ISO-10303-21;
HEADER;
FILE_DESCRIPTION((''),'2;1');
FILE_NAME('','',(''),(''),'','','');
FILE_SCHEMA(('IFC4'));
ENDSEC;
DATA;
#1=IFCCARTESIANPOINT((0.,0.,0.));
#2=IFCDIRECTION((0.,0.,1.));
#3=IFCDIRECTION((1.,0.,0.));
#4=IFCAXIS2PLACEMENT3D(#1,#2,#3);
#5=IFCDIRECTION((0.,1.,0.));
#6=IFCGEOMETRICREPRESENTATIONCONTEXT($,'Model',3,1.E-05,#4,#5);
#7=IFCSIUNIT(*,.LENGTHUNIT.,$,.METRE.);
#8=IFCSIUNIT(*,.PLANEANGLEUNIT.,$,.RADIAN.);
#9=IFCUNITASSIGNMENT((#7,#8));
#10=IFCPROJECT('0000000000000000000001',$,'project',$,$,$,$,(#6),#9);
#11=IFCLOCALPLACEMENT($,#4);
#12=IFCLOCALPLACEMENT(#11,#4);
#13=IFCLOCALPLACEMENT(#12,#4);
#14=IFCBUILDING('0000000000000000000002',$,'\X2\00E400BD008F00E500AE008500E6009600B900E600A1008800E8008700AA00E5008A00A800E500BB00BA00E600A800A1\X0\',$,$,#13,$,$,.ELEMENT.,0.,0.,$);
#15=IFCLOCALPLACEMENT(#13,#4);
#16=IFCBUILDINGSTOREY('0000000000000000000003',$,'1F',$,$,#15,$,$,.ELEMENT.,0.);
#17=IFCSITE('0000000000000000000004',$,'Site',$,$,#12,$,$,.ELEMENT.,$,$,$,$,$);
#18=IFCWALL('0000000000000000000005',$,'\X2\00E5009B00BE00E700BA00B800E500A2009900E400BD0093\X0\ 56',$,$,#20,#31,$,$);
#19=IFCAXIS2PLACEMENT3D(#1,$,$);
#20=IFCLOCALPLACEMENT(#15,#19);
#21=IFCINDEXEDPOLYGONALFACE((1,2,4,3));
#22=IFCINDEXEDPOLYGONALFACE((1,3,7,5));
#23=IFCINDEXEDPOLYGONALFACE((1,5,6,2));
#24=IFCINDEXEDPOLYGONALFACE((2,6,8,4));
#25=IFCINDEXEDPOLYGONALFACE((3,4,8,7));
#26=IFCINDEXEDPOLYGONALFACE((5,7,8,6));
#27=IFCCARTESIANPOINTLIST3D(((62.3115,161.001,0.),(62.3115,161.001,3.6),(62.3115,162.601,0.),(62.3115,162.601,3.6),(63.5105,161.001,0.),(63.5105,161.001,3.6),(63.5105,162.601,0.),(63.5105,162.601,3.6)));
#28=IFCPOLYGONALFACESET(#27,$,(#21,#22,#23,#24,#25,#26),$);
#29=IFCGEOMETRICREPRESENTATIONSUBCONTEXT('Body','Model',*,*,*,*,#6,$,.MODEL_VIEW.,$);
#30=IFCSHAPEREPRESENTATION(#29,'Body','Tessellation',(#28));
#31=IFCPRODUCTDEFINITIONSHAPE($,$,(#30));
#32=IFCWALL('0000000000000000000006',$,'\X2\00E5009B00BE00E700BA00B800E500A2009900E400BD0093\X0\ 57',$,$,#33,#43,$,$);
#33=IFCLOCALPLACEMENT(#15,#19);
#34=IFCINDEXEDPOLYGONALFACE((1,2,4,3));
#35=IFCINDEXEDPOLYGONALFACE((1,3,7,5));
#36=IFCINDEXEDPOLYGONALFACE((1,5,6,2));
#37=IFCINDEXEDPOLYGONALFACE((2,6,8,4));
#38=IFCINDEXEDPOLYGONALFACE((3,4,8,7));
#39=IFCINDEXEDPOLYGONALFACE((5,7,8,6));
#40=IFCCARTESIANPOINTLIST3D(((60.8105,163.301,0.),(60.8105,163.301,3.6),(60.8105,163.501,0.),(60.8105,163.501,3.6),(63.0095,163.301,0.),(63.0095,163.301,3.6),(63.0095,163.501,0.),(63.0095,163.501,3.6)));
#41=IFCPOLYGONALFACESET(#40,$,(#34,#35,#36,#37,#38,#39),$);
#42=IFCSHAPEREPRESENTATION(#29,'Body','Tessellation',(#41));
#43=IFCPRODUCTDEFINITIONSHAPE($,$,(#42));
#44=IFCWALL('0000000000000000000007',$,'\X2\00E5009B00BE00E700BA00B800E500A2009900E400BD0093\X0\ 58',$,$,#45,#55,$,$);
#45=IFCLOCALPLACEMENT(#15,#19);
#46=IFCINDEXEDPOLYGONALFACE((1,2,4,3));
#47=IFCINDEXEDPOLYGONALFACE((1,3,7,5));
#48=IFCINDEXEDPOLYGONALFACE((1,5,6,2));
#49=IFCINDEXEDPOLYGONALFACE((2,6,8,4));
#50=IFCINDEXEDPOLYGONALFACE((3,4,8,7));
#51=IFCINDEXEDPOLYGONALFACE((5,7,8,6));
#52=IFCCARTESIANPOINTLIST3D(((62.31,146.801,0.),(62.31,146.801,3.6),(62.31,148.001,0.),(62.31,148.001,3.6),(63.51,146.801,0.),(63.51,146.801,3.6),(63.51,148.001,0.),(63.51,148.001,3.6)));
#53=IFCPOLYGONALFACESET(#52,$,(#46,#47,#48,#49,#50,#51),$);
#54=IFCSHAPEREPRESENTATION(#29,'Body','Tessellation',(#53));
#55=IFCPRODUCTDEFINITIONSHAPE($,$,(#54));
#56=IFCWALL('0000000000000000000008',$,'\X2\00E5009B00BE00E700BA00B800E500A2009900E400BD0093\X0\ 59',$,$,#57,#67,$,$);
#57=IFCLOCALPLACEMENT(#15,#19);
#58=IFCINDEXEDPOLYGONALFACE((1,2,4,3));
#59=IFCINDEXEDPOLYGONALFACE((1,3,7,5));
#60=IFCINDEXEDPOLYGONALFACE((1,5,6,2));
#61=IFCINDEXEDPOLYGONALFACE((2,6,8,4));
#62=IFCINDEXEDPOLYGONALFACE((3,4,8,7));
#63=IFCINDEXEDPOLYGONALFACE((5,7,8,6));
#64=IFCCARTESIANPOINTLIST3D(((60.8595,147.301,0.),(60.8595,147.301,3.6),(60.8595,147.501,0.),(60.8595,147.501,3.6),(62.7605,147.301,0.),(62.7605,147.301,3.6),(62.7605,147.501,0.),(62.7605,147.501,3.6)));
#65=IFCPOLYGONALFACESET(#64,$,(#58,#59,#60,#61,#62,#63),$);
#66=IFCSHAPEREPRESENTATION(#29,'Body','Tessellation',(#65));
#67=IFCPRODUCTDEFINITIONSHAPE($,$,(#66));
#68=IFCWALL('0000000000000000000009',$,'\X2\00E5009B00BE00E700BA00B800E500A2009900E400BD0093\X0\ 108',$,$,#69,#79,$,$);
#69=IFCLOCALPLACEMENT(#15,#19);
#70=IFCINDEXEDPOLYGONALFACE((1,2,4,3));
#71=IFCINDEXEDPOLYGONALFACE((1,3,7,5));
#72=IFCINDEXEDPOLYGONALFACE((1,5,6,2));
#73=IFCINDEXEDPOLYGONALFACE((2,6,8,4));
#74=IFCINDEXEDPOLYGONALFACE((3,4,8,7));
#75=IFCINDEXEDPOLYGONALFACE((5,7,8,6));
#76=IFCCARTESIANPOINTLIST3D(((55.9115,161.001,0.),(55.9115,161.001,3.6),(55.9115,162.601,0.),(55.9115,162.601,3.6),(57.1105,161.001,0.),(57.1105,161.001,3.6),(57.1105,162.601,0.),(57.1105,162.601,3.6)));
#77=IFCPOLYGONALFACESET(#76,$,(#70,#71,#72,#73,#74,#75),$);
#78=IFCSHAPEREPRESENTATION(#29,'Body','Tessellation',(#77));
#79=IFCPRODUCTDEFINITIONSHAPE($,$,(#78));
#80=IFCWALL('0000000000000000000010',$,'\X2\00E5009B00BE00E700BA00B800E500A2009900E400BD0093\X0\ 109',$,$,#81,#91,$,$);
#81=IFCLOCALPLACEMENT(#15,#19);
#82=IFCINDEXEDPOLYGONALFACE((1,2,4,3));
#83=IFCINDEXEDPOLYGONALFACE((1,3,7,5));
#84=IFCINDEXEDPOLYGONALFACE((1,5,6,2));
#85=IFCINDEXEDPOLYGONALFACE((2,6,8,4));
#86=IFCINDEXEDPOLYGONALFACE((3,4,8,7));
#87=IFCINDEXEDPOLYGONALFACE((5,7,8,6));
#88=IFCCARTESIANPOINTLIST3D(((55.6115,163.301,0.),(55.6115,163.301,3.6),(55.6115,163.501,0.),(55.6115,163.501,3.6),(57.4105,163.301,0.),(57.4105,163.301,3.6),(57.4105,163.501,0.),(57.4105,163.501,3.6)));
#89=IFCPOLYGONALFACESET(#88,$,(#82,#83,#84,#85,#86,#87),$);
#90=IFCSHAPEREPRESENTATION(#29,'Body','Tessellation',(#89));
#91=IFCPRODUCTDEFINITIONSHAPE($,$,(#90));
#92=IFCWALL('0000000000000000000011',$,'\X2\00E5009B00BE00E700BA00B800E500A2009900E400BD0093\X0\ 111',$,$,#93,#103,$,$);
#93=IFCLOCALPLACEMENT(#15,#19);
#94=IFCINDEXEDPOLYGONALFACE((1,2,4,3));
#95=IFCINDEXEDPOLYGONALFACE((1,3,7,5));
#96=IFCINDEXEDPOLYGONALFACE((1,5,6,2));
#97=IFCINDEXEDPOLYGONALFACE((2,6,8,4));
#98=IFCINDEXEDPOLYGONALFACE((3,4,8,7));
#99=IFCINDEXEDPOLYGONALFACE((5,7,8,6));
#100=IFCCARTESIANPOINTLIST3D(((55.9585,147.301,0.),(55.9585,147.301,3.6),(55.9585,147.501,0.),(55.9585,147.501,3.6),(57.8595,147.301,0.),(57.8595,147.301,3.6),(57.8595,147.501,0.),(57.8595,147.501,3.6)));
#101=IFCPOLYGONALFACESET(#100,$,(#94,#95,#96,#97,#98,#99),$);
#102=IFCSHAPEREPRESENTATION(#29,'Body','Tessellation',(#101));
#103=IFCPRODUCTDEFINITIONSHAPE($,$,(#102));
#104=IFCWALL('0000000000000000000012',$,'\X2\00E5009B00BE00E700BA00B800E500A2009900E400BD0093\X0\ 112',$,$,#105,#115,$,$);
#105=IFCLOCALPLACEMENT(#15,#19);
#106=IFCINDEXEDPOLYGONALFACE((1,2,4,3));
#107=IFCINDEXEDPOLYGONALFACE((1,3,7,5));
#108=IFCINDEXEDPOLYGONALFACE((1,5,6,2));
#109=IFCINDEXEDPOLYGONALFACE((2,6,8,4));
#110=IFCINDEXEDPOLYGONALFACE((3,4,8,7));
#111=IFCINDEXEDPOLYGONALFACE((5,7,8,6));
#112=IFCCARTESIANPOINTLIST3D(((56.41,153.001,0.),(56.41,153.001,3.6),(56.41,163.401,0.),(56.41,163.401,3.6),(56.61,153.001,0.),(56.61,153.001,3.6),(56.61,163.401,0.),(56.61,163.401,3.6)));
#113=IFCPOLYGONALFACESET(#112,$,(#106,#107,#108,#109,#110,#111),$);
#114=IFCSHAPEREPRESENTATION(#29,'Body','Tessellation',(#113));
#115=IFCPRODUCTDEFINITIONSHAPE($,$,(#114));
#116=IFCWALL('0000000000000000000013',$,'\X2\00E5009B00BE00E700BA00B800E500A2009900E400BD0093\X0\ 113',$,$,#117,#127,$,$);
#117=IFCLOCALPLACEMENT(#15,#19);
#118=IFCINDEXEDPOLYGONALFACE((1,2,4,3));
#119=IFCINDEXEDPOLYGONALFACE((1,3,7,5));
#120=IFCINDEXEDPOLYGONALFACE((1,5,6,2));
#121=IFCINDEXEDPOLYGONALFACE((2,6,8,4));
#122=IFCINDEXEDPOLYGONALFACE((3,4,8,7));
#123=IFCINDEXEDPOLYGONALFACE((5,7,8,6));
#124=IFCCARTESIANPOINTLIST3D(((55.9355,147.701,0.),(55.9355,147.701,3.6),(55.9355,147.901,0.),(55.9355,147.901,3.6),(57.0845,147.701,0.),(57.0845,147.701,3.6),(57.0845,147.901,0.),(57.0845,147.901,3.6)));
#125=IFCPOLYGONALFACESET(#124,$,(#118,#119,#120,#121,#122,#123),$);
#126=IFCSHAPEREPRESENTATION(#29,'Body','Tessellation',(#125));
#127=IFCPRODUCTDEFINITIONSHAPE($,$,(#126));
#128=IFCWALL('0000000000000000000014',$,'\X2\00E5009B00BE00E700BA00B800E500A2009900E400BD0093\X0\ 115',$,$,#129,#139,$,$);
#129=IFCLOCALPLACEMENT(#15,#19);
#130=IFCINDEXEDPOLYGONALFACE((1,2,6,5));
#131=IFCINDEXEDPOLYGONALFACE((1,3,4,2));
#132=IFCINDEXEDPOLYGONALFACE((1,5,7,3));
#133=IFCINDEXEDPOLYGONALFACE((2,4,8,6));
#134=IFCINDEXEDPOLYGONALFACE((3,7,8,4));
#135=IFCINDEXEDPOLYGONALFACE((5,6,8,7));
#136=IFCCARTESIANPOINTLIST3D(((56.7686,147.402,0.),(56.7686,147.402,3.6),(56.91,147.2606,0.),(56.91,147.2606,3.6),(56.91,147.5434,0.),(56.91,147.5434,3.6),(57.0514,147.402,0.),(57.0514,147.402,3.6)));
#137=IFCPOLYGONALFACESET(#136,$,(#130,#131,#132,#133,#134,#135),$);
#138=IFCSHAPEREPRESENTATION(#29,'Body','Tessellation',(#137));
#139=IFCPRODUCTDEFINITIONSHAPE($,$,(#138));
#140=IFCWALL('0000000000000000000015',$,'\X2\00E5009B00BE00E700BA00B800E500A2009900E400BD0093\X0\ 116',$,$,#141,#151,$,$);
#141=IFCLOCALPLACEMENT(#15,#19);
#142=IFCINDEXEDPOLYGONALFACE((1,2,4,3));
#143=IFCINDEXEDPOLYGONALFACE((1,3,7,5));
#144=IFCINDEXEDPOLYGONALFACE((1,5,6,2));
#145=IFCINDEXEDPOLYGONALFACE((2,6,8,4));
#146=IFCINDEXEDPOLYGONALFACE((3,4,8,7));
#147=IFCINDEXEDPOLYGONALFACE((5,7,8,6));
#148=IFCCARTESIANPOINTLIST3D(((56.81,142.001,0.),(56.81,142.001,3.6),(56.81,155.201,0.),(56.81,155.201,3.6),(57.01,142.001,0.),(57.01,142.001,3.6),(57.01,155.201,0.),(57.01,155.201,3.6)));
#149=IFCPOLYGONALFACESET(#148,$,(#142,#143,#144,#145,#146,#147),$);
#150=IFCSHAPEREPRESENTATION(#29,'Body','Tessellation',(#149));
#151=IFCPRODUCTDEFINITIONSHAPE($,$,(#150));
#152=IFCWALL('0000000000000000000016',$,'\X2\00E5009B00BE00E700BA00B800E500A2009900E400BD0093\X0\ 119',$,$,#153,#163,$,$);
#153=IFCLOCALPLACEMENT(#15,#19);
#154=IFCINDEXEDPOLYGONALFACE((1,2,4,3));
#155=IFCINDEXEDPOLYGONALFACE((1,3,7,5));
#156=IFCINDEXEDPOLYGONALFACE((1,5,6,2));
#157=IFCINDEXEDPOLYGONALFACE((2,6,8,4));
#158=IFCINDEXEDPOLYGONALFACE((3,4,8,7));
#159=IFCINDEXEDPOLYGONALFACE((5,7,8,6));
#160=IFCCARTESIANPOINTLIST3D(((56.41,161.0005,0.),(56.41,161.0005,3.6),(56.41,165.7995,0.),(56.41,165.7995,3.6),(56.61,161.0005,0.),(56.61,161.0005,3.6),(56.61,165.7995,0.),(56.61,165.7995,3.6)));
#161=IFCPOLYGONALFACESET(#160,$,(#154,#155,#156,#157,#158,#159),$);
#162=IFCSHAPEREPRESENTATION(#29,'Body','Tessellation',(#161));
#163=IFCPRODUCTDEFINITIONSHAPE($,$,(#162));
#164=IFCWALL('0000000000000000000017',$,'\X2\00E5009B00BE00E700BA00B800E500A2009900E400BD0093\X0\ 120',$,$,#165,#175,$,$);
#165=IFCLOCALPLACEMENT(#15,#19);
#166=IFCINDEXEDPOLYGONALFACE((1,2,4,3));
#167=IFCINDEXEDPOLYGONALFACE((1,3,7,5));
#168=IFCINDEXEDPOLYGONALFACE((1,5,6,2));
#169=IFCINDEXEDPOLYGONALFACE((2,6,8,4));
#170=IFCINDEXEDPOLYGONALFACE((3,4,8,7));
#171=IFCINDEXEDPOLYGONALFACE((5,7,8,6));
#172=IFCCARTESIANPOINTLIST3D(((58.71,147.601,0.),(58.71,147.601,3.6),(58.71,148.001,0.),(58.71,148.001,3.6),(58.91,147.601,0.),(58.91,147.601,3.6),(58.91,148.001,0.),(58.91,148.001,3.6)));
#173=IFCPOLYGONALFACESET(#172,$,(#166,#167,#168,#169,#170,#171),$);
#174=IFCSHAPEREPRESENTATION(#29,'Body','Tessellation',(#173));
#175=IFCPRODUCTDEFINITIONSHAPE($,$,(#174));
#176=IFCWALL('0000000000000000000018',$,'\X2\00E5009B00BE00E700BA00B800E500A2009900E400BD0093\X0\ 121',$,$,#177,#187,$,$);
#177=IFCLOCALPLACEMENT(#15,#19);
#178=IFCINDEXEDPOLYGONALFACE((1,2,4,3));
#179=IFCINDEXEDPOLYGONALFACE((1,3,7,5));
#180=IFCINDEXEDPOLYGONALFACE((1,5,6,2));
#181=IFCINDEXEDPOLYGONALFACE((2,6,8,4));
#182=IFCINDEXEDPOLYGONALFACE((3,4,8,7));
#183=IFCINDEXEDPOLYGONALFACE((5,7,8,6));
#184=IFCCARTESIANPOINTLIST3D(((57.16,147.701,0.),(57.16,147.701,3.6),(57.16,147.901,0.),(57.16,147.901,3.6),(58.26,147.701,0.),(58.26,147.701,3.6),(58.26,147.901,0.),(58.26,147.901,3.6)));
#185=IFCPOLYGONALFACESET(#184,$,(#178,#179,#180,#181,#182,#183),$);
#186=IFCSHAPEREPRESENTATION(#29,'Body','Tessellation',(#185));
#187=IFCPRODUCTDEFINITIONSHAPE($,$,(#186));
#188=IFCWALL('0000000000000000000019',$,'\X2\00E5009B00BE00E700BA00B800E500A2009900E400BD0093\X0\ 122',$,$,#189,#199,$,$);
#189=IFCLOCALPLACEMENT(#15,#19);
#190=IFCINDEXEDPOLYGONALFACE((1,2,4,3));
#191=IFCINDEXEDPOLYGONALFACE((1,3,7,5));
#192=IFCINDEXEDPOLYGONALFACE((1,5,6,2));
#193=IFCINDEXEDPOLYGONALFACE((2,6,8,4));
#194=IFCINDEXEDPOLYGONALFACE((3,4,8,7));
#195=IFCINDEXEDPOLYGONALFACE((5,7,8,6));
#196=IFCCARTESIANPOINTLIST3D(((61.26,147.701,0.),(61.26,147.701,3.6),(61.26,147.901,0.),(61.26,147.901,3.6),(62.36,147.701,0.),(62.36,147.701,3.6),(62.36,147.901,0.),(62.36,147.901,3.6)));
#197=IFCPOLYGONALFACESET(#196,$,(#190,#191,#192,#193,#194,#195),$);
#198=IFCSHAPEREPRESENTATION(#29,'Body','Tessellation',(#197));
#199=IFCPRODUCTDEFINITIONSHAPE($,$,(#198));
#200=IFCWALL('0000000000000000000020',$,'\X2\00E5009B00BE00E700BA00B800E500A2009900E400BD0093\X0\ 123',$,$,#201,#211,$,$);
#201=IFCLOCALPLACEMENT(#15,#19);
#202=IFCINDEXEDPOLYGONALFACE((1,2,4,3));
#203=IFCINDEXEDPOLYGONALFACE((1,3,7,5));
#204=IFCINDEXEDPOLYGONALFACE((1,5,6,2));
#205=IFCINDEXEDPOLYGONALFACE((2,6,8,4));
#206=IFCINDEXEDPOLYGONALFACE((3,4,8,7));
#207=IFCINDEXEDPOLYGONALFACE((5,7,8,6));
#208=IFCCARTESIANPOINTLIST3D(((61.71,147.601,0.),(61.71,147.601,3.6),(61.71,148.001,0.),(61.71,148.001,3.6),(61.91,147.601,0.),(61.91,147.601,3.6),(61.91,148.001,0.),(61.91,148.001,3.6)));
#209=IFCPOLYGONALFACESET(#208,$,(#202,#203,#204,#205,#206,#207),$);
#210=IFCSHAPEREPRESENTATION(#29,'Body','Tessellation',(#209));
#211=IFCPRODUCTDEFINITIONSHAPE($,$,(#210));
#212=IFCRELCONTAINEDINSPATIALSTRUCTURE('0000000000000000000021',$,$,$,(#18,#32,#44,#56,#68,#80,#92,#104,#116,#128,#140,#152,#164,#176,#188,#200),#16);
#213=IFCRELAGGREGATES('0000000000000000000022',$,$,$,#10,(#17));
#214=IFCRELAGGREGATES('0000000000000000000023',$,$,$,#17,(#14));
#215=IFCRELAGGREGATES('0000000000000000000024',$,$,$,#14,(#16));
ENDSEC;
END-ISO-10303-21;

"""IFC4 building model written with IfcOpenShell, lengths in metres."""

from ifc_helpers import new_model, si_unit, direction, frame, frame_2d, origin_with_axes, place, context, subcontext, project, spatial, rectangle, extrude, element, save


model = new_model("IFC4")

# Units and contexts
model_context = context("Model", 3, precision=1e-05, world=origin_with_axes(), true_north=direction((0.0, 1.0, 0.0)))
body_context = subcontext(model_context, "Body", "Model", "MODEL_VIEW")
ifc_project = project(units=[si_unit("LENGTHUNIT", "METRE"), si_unit("PLANEANGLEUNIT", "RADIAN")], contexts=[model_context])

# Site, building, storey
placement = place(None, origin_with_axes())
site_placement = place(placement, origin_with_axes())
site = spatial("IfcSite", under=ifc_project, at=site_placement, Name="Site", CompositionType="ELEMENT")
building_placement = place(site_placement, origin_with_axes())
building = spatial("IfcBuilding", under=site, at=building_placement, Name="ä½\u008få®\u0085æ\u0096¹æ¡\u0088è\u0087ªå\u008a¨å»ºæ¨¡", CompositionType="ELEMENT", ElevationOfRefHeight=0.0, ElevationOfTerrain=0.0)
storey_placement = place(building_placement, origin_with_axes())
storey = spatial("IfcBuildingStorey", under=building, at=storey_placement, Name="1F", CompositionType="ELEMENT", Elevation=0.0)

# Walls
wall_1_placement = place(storey_placement, frame((62.911, 161.801, 0.0), z_axis=(0.0, 0.0, 1.0), x_axis=(1.0, 0.0, 0.0)))
element("IfcWall", 1, at=wall_1_placement, inside=storey, Name="å\u009b¾çº¸å¢\u0099ä½\u0093 56", context=body_context, shape_type="SweptSolid", body=[
    extrude(rectangle(XDim=1.199, YDim=1.6, at=frame_2d((0.0, 0.0), x_axis=(1.0, 0.0, 0.0))), frame((0.0, 0.0, 0.0), z_axis=(0.0, 0.0, 1.0)), (0.0, 0.0, 1.0), 3.6),
])
wall_2_placement = place(storey_placement, frame((61.91, 163.401, 0.0), z_axis=(0.0, 0.0, 1.0), x_axis=(1.0, 0.0, 0.0)))
element("IfcWall", 2, at=wall_2_placement, inside=storey, Name="å\u009b¾çº¸å¢\u0099ä½\u0093 57", context=body_context, shape_type="SweptSolid", body=[
    extrude(rectangle(XDim=2.199, YDim=0.2, at=frame_2d((0.0, 0.0), x_axis=(1.0, 0.0, 0.0))), frame((0.0, 0.0, 0.0), z_axis=(0.0, 0.0, 1.0)), (0.0, 0.0, 1.0), 3.6),
])
wall_3_placement = place(storey_placement, frame((62.91, 147.401, 0.0), z_axis=(0.0, 0.0, 1.0), x_axis=(1.0, 0.0, 0.0)))
element("IfcWall", 3, at=wall_3_placement, inside=storey, Name="å\u009b¾çº¸å¢\u0099ä½\u0093 58", context=body_context, shape_type="SweptSolid", body=[
    extrude(rectangle(XDim=1.2, YDim=1.2, at=frame_2d((0.0, 0.0), x_axis=(1.0, 0.0, 0.0))), frame((0.0, 0.0, 0.0), z_axis=(0.0, 0.0, 1.0)), (0.0, 0.0, 1.0), 3.6),
])
wall_4_placement = place(storey_placement, frame((61.81, 147.401, 0.0), z_axis=(0.0, 0.0, 1.0), x_axis=(1.0, 0.0, 0.0)))
element("IfcWall", 4, at=wall_4_placement, inside=storey, Name="å\u009b¾çº¸å¢\u0099ä½\u0093 59", context=body_context, shape_type="SweptSolid", body=[
    extrude(rectangle(XDim=1.901, YDim=0.2, at=frame_2d((0.0, 0.0), x_axis=(1.0, 0.0, 0.0))), frame((0.0, 0.0, 0.0), z_axis=(0.0, 0.0, 1.0)), (0.0, 0.0, 1.0), 3.6),
])
wall_5_placement = place(storey_placement, frame((56.511, 161.801, 0.0), z_axis=(0.0, 0.0, 1.0), x_axis=(1.0, 0.0, 0.0)))
element("IfcWall", 5, at=wall_5_placement, inside=storey, Name="å\u009b¾çº¸å¢\u0099ä½\u0093 108", context=body_context, shape_type="SweptSolid", body=[
    extrude(rectangle(XDim=1.199, YDim=1.6, at=frame_2d((0.0, 0.0), x_axis=(1.0, 0.0, 0.0))), frame((0.0, 0.0, 0.0), z_axis=(0.0, 0.0, 1.0)), (0.0, 0.0, 1.0), 3.6),
])
wall_6_placement = place(storey_placement, frame((56.511, 163.401, 0.0), z_axis=(0.0, 0.0, 1.0), x_axis=(1.0, 0.0, 0.0)))
element("IfcWall", 6, at=wall_6_placement, inside=storey, Name="å\u009b¾çº¸å¢\u0099ä½\u0093 109", context=body_context, shape_type="SweptSolid", body=[
    extrude(rectangle(XDim=1.799, YDim=0.2, at=frame_2d((0.0, 0.0), x_axis=(1.0, 0.0, 0.0))), frame((0.0, 0.0, 0.0), z_axis=(0.0, 0.0, 1.0)), (0.0, 0.0, 1.0), 3.6),
])
wall_7_placement = place(storey_placement, frame((56.909, 147.401, 0.0), z_axis=(0.0, 0.0, 1.0), x_axis=(1.0, 0.0, 0.0)))
element("IfcWall", 7, at=wall_7_placement, inside=storey, Name="å\u009b¾çº¸å¢\u0099ä½\u0093 111", context=body_context, shape_type="SweptSolid", body=[
    extrude(rectangle(XDim=1.901, YDim=0.2, at=frame_2d((0.0, 0.0), x_axis=(1.0, 0.0, 0.0))), frame((0.0, 0.0, 0.0), z_axis=(0.0, 0.0, 1.0)), (0.0, 0.0, 1.0), 3.6),
])
wall_8_placement = place(storey_placement, frame((56.51, 158.201, 0.0), z_axis=(0.0, 0.0, 1.0), x_axis=(0.0, -1.0, 0.0)))
element("IfcWall", 8, at=wall_8_placement, inside=storey, Name="å\u009b¾çº¸å¢\u0099ä½\u0093 112", context=body_context, shape_type="SweptSolid", body=[
    extrude(rectangle(XDim=10.4, YDim=0.2, at=frame_2d((0.0, 0.0), x_axis=(1.0, 0.0, 0.0))), frame((0.0, 0.0, 0.0), z_axis=(0.0, 0.0, 1.0)), (0.0, 0.0, 1.0), 3.6),
])
wall_9_placement = place(storey_placement, frame((56.51, 147.801, 0.0), z_axis=(0.0, 0.0, 1.0), x_axis=(-1.0, 0.0, 0.0)))
element("IfcWall", 9, at=wall_9_placement, inside=storey, Name="å\u009b¾çº¸å¢\u0099ä½\u0093 113", context=body_context, shape_type="SweptSolid", body=[
    extrude(rectangle(XDim=1.149, YDim=0.2, at=frame_2d((0.0, 0.0), x_axis=(1.0, 0.0, 0.0))), frame((0.0, 0.0, 0.0), z_axis=(0.0, 0.0, 1.0)), (0.0, 0.0, 1.0), 3.6),
])
wall_10_placement = place(storey_placement, frame((56.91, 147.402, 0.0), z_axis=(0.0, 0.0, 1.0), x_axis=(-0.707107, -0.707107, 0.0)))
element("IfcWall", 10, at=wall_10_placement, inside=storey, Name="å\u009b¾çº¸å¢\u0099ä½\u0093 115", context=body_context, shape_type="SweptSolid", body=[
    extrude(rectangle(XDim=0.2, YDim=0.2, at=frame_2d((0.0, 0.0), x_axis=(1.0, 0.0, 0.0))), frame((0.0, 0.0, 0.0), z_axis=(0.0, 0.0, 1.0)), (0.0, 0.0, 1.0), 3.6),
])
wall_11_placement = place(storey_placement, frame((56.91, 148.601, 0.0), z_axis=(0.0, 0.0, 1.0), x_axis=(0.0, 1.0, 0.0)))
element("IfcWall", 11, at=wall_11_placement, inside=storey, Name="å\u009b¾çº¸å¢\u0099ä½\u0093 116", context=body_context, shape_type="SweptSolid", body=[
    extrude(rectangle(XDim=13.2, YDim=0.2, at=frame_2d((0.0, 0.0), x_axis=(1.0, 0.0, 0.0))), frame((0.0, 0.0, 0.0), z_axis=(0.0, 0.0, 1.0)), (0.0, 0.0, 1.0), 3.6),
])
wall_12_placement = place(storey_placement, frame((56.51, 163.4, 0.0), z_axis=(0.0, 0.0, 1.0), x_axis=(0.0, -1.0, 0.0)))
element("IfcWall", 12, at=wall_12_placement, inside=storey, Name="å\u009b¾çº¸å¢\u0099ä½\u0093 119", context=body_context, shape_type="SweptSolid", body=[
    extrude(rectangle(XDim=4.799, YDim=0.2, at=frame_2d((0.0, 0.0), x_axis=(1.0, 0.0, 0.0))), frame((0.0, 0.0, 0.0), z_axis=(0.0, 0.0, 1.0)), (0.0, 0.0, 1.0), 3.6),
])
wall_13_placement = place(storey_placement, frame((58.81, 147.801, 0.0), z_axis=(0.0, 0.0, 1.0), x_axis=(0.0, -1.0, 0.0)))
element("IfcWall", 13, at=wall_13_placement, inside=storey, Name="å\u009b¾çº¸å¢\u0099ä½\u0093 120", context=body_context, shape_type="SweptSolid", body=[
    extrude(rectangle(XDim=0.4, YDim=0.2, at=frame_2d((0.0, 0.0), x_axis=(1.0, 0.0, 0.0))), frame((0.0, 0.0, 0.0), z_axis=(0.0, 0.0, 1.0)), (0.0, 0.0, 1.0), 3.6),
])
for number, where, z_axis, x_axis, name in (
    (14, (57.71, 147.801, 0.0), (0.0, 0.0, 1.0), (1.0, 0.0, 0.0), "å\u009b¾çº¸å¢\u0099ä½\u0093 121"),
    (15, (61.81, 147.801, 0.0), (0.0, 0.0, 1.0), (1.0, 0.0, 0.0), "å\u009b¾çº¸å¢\u0099ä½\u0093 122"),
):
    element("IfcWall", number, at=place(storey_placement, frame(where, z_axis=z_axis, x_axis=x_axis)), inside=storey, Name=name, context=body_context, shape_type="SweptSolid", body=[
        extrude(rectangle(XDim=1.1, YDim=0.2, at=frame_2d((0.0, 0.0), x_axis=(1.0, 0.0, 0.0))), frame((0.0, 0.0, 0.0), z_axis=(0.0, 0.0, 1.0)), (0.0, 0.0, 1.0), 3.6),
    ])
for number, where, z_axis, x_axis, name in (
    (16, (61.81, 147.801, 0.0), (0.0, 0.0, 1.0), (0.0, -1.0, 0.0), "å\u009b¾çº¸å¢\u0099ä½\u0093 123"),
):
    element("IfcWall", number, at=place(storey_placement, frame(where, z_axis=z_axis, x_axis=x_axis)), inside=storey, Name=name, context=body_context, shape_type="SweptSolid", body=[
        extrude(rectangle(XDim=0.4, YDim=0.2, at=frame_2d((0.0, 0.0), x_axis=(1.0, 0.0, 0.0))), frame((0.0, 0.0, 0.0), z_axis=(0.0, 0.0, 1.0)), (0.0, 0.0, 1.0), 3.6),
    ])

save(model, "model.ifc")
